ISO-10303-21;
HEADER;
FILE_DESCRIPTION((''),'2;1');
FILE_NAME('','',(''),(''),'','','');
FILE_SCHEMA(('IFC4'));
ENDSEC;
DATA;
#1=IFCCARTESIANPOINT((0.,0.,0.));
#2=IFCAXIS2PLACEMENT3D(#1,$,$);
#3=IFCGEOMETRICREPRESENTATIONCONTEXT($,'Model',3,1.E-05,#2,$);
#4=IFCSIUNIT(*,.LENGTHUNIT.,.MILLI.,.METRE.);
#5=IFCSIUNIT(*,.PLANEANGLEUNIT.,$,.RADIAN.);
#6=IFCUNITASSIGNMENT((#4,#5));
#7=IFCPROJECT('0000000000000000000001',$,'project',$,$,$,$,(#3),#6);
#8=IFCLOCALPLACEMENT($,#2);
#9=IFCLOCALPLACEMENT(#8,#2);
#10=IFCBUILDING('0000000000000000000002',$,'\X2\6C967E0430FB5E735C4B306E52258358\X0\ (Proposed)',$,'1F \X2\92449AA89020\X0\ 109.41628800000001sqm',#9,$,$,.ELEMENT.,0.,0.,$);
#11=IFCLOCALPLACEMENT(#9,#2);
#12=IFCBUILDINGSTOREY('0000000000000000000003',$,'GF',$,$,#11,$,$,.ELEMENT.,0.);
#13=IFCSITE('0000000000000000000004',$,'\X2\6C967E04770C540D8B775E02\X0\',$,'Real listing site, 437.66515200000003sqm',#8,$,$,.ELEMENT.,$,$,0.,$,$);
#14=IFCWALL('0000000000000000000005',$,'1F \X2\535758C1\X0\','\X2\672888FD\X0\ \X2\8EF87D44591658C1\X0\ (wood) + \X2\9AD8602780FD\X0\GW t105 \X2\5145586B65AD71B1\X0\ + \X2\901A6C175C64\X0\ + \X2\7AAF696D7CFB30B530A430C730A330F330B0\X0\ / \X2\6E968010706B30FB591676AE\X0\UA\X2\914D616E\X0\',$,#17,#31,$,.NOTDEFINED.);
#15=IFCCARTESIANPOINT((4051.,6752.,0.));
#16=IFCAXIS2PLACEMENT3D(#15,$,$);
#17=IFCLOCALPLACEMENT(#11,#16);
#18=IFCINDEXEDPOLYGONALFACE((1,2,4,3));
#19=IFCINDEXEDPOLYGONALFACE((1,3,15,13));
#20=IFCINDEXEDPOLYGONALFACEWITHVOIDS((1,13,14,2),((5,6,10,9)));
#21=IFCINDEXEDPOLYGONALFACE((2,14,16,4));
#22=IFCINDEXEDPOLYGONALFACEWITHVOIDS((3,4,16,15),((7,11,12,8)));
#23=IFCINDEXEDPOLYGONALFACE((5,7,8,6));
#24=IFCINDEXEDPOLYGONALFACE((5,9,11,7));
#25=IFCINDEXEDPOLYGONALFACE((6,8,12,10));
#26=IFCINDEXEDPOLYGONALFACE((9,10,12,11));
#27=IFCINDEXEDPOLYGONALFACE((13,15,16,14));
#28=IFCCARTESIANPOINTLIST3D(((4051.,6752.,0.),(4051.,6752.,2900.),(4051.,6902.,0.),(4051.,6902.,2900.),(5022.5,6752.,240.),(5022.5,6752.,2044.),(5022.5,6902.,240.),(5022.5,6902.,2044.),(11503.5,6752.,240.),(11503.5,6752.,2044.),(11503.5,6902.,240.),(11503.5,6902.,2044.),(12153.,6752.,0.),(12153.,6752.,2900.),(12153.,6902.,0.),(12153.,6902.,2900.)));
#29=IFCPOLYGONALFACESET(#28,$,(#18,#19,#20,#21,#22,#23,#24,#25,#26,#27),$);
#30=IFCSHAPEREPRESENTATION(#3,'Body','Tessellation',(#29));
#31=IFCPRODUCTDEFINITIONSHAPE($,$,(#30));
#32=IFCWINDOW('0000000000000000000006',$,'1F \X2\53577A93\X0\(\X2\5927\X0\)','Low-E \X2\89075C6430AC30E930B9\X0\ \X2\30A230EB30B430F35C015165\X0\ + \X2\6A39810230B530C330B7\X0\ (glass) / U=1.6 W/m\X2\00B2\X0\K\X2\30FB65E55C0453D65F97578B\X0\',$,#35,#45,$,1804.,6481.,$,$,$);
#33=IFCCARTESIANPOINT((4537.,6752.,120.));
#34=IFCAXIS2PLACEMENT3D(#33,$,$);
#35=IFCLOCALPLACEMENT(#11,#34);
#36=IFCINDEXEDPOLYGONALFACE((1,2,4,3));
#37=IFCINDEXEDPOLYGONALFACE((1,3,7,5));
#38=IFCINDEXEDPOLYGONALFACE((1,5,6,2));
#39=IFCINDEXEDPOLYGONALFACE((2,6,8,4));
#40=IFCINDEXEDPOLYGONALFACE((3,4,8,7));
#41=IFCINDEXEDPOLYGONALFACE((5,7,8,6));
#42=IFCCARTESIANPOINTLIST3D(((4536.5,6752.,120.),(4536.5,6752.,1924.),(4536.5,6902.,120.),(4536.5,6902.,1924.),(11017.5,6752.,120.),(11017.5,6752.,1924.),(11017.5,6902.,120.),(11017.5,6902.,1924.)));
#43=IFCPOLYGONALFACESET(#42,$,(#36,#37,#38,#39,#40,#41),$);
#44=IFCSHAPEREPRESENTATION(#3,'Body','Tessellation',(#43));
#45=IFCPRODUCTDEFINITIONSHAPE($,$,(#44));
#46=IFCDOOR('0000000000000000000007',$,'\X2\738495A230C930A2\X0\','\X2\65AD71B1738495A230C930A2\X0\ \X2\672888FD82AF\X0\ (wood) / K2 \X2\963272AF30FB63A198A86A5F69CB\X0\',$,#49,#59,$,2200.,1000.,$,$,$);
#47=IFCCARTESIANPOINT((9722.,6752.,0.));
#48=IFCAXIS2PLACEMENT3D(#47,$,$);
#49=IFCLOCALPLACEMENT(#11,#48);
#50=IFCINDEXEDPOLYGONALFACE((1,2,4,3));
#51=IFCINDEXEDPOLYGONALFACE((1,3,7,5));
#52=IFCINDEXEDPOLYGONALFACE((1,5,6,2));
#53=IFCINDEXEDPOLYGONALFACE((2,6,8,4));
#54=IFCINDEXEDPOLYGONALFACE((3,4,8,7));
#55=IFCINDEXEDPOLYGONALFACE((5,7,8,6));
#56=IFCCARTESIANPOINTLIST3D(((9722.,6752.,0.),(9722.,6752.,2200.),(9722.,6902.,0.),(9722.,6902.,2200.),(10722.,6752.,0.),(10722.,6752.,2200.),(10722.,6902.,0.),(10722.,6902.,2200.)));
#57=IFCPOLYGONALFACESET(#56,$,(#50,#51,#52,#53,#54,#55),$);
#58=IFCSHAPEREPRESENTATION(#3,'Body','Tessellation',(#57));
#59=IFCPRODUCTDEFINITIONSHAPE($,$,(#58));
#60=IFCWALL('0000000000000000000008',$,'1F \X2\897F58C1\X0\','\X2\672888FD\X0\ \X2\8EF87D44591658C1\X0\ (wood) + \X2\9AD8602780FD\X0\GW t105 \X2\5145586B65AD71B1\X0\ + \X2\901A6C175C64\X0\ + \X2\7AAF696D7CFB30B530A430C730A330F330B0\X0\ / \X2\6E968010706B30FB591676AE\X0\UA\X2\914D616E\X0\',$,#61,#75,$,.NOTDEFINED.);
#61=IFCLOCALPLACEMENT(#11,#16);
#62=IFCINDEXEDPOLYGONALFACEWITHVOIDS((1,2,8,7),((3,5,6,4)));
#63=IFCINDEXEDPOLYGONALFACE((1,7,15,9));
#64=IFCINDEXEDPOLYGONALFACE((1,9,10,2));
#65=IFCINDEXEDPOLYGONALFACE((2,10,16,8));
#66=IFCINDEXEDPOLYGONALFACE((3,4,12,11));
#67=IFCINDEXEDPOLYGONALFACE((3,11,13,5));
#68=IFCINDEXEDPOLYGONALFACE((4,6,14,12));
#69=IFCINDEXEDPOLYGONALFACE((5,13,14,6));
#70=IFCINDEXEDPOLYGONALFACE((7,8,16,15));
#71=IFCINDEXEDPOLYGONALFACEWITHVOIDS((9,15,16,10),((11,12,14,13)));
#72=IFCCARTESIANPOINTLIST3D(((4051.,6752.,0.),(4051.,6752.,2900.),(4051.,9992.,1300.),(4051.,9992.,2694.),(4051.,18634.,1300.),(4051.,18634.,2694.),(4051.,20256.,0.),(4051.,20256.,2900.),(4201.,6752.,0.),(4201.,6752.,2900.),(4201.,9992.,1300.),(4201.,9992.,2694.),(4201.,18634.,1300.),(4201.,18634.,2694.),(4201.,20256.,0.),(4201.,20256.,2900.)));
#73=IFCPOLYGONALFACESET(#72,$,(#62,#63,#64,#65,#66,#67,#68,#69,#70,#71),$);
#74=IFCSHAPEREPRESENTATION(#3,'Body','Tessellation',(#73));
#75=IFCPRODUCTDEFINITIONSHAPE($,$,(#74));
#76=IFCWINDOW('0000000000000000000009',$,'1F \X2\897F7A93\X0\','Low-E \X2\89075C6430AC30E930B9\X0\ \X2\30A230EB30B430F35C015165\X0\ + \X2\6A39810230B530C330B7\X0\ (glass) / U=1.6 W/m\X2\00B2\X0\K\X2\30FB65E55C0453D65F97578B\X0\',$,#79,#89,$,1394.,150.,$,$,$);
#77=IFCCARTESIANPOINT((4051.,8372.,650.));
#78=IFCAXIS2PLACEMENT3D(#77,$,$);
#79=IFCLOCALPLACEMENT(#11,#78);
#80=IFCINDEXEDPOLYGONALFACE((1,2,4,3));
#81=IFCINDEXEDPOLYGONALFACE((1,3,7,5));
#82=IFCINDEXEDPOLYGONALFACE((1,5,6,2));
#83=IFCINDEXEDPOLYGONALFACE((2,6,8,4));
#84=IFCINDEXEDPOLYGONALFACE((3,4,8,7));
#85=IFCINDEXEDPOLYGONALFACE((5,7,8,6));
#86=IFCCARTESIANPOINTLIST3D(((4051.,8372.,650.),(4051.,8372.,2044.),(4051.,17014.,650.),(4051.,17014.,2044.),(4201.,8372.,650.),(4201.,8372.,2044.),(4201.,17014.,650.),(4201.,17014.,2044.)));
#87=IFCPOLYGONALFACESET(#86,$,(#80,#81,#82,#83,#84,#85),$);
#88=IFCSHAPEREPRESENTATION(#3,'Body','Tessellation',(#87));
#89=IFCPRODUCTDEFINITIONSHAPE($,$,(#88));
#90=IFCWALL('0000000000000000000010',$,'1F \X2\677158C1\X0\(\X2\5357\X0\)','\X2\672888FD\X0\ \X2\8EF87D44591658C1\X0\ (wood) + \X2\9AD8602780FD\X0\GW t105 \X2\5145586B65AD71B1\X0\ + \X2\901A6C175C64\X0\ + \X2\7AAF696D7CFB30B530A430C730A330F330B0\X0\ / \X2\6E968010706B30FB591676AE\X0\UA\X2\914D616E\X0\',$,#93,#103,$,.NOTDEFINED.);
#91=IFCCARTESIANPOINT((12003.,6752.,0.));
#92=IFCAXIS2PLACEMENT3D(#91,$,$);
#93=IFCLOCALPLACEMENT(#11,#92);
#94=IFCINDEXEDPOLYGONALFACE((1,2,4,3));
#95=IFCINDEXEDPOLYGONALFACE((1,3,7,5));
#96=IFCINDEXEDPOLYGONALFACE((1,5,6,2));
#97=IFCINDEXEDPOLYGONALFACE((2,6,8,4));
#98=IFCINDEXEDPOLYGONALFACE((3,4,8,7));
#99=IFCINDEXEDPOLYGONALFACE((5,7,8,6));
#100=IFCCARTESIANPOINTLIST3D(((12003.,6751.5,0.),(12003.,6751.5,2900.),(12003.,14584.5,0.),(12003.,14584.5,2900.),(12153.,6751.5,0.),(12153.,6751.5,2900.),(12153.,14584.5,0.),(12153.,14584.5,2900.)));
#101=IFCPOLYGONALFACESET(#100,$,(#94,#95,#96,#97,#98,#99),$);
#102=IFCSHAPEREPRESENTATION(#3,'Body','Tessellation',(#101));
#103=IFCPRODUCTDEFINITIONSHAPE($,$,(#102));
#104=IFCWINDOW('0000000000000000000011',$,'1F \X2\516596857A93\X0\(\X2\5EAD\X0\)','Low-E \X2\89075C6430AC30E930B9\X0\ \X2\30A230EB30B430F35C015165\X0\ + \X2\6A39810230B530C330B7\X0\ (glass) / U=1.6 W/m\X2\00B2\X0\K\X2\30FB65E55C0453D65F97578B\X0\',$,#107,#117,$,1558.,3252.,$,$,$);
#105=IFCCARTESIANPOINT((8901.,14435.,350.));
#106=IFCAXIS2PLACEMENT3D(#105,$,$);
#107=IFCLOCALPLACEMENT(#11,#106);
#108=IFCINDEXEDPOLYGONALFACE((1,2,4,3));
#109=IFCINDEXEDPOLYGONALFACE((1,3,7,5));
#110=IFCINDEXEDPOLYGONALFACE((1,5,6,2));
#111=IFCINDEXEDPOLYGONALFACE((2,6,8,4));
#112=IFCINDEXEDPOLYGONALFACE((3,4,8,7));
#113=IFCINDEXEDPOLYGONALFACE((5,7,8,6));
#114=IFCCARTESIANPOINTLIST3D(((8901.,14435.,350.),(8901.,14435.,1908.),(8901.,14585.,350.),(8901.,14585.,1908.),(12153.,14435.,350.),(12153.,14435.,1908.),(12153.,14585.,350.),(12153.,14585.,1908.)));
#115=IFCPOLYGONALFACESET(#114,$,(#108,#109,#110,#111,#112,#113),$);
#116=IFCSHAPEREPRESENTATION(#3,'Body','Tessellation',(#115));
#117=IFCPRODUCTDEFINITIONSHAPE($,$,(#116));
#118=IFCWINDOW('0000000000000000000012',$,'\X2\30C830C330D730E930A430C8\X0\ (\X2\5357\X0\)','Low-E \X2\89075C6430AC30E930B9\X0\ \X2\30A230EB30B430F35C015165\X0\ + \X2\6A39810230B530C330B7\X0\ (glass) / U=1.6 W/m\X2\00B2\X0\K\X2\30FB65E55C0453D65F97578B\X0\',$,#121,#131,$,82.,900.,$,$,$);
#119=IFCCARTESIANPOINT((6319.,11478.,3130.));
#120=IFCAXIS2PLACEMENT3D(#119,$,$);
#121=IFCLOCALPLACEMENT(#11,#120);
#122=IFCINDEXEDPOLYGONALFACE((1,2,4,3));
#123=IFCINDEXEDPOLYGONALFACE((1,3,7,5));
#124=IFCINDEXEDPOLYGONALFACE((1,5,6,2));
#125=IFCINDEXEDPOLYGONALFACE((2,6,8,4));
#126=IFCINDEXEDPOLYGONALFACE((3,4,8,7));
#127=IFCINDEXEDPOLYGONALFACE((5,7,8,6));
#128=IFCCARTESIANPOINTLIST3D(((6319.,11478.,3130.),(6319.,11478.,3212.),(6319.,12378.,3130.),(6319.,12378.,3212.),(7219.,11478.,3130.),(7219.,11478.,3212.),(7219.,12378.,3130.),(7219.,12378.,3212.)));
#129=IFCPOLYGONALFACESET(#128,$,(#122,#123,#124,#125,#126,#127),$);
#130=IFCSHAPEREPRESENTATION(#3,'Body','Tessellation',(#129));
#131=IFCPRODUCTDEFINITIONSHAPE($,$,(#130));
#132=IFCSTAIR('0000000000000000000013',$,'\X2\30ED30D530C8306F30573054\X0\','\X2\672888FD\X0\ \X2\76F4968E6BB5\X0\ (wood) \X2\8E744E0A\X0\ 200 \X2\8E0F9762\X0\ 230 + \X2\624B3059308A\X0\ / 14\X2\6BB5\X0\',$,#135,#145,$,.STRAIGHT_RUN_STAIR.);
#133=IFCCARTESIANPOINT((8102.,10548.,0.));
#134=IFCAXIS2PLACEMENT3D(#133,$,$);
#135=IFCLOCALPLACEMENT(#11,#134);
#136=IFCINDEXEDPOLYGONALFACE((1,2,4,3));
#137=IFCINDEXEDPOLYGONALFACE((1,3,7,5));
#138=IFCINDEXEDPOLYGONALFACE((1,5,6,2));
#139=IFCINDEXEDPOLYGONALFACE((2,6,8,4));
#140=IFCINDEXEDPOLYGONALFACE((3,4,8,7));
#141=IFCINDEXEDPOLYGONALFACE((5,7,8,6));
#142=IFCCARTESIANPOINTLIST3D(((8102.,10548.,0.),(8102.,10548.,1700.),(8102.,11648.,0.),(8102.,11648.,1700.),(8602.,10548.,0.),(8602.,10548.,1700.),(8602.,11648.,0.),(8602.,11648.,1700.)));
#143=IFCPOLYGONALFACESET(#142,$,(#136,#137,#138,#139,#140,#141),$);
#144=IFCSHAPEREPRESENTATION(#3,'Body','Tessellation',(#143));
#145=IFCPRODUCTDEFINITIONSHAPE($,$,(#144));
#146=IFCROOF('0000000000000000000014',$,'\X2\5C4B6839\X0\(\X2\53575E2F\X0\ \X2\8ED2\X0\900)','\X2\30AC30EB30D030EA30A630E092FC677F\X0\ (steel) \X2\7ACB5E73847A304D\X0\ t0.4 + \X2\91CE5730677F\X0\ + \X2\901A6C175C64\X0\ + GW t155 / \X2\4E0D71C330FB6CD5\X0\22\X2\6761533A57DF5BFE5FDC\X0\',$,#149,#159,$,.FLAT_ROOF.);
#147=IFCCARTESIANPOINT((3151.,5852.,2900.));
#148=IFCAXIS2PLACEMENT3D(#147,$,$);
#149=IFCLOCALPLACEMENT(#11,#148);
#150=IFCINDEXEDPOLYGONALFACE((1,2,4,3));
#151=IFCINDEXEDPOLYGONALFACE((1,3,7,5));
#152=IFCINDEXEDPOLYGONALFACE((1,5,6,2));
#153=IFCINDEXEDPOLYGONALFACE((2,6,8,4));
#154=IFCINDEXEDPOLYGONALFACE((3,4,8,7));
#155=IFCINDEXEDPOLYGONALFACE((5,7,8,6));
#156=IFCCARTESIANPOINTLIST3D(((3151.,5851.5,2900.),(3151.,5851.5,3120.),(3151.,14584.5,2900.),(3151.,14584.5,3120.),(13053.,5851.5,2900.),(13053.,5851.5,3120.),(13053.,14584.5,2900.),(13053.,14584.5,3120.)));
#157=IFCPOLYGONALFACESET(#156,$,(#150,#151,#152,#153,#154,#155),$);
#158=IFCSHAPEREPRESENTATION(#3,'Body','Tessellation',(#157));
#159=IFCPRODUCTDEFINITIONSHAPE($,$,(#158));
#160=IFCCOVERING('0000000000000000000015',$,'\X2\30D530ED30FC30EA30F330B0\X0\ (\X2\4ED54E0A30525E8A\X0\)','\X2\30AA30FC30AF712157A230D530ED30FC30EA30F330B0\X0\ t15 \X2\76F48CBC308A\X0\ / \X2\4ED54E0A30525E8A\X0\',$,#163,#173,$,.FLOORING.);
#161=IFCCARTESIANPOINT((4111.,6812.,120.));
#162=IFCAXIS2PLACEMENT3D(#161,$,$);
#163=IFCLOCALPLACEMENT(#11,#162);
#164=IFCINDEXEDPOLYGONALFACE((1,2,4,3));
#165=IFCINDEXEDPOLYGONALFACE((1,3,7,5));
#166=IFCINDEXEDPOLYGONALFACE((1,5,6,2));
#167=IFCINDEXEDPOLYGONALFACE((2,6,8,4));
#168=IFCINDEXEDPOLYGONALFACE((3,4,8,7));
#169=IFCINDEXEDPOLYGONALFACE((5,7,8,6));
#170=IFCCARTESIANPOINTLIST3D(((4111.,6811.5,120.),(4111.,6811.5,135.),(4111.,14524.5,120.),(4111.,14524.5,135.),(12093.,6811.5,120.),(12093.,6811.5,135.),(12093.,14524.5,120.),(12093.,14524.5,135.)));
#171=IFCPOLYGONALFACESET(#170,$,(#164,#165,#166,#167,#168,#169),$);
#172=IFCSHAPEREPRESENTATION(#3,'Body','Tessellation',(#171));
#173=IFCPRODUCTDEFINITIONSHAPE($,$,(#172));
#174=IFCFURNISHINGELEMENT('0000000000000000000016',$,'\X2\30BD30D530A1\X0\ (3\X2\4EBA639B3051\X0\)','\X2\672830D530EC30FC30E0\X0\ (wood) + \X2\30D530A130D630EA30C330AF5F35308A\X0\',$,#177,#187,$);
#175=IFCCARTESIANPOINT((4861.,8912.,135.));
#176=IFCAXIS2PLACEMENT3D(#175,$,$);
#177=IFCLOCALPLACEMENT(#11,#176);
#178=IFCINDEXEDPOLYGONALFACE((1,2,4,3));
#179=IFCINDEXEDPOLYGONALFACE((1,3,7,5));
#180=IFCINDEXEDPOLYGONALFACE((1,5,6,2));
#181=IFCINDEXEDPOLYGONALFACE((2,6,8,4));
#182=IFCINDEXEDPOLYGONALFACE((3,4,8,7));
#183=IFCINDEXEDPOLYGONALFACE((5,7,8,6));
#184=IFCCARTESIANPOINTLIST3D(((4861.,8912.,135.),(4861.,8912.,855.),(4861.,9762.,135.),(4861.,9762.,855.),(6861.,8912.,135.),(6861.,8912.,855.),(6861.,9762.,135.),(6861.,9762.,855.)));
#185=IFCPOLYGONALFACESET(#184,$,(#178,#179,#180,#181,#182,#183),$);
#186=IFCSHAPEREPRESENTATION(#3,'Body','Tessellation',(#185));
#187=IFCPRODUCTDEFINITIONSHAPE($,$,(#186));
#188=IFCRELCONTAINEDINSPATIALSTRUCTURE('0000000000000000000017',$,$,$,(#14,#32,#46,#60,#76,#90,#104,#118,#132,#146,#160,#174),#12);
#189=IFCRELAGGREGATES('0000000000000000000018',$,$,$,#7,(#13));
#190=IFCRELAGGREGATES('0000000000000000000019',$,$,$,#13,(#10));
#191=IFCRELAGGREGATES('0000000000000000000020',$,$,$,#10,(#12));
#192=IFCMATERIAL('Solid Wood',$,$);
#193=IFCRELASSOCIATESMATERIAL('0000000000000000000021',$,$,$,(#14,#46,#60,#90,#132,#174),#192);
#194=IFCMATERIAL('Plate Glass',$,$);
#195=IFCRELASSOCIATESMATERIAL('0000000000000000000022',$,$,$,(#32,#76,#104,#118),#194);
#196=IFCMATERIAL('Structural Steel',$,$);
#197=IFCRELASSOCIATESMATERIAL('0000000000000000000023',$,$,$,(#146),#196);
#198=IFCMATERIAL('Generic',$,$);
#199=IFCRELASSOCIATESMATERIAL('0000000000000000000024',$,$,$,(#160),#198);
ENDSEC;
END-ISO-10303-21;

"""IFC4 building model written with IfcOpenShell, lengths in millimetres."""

from ifc_helpers import new_model, si_unit, frame, frame_2d, origin, place, context, project, spatial, rectangle, extrude, material, element, fill, save


model = new_model("IFC4")

# Units and contexts
model_context = context("Model", 3, precision=1e-05, world=origin())
ifc_project = project(units=[si_unit("LENGTHUNIT", "METRE", prefix="MILLI"), si_unit("PLANEANGLEUNIT", "RADIAN")], contexts=[model_context])

# Site, building, storey
site_placement = place(None, origin())
site = spatial("IfcSite", under=ifc_project, at=site_placement, Name="沖縄県名護市", ObjectType="Real listing site, 437.66515200000003sqm", CompositionType="ELEMENT", RefElevation=0.0)
building_placement = place(site_placement, origin())
building = spatial("IfcBuilding", under=site, at=building_placement, Name="沖縄・平屋の別荘 (Proposed)", ObjectType="1F 鉄骨造 109.41628800000001sqm", CompositionType="ELEMENT", ElevationOfRefHeight=0.0, ElevationOfTerrain=0.0)
storey_placement = place(building_placement, origin())
storey = spatial("IfcBuildingStorey", under=building, at=storey_placement, Name="GF", CompositionType="ELEMENT", Elevation=0.0)

# Shared definitions
ifc_material_1 = material(Name="Solid Wood")

# Wall, openings, window, door
wall_1_placement = place(storey_placement, frame((4051.0, 6752.0, 0.0)))
wall_1 = element("IfcWall", 1, at=wall_1_placement, inside=storey, material=ifc_material_1, Name="1F 南壁", Description="木製 軸組外壁 (wood) + 高性能GW t105 充填断熱 + 通気層 + 窯業系サイディング / 準耐火・外皮UA配慮", PredefinedType="NOTDEFINED", context=model_context, shape_type="SweptSolid", body=[
    extrude(rectangle(XDim=8102.0, YDim=150.0, at=frame_2d((4051.0, 75.0))), frame((4051.0, 6752.0, 0.0)), (0.0, 0.0, 1.0), 2900.0),
])
opening_1_placement = place(storey_placement, frame((4537.0, 6752.0, 120.0)))
opening_1 = element("IfcOpeningElement", 2, at=opening_1_placement, cuts=wall_1, PredefinedType="NOTDEFINED", context=model_context, shape_type="SweptSolid", body=[
    extrude(rectangle(XDim=6481.0, YDim=150.0, at=frame_2d((3240.0, 75.0))), frame((4537.0, 6752.0, 120.0)), (0.0, 0.0, 1.0), 1804.0),
])
opening_2_placement = place(storey_placement, frame((9722.0, 6752.0, 0.0)))
opening_2 = element("IfcOpeningElement", 3, at=opening_2_placement, cuts=wall_1, PredefinedType="NOTDEFINED", context=model_context, shape_type="SweptSolid", body=[
    extrude(rectangle(XDim=1000.0, YDim=150.0, at=frame_2d((500.0, 75.0))), frame((9722.0, 6752.0, 0.0)), (0.0, 0.0, 1.0), 2200.0),
])
ifc_material_2 = material(Name="Plate Glass")
window_1_placement = place(storey_placement, frame((4537.0, 6752.0, 120.0)))
window_1 = element("IfcWindow", 4, at=window_1_placement, inside=storey, material=ifc_material_2, Name="1F 南窓(大)", Description="Low-E 複層ガラス アルゴン封入 + 樹脂サッシ (glass) / U=1.6 W/m²K・日射取得型", OverallHeight=1804.0, OverallWidth=6481.0, context=model_context, shape_type="SweptSolid", body=[
    extrude(rectangle(XDim=6481.0, YDim=150.0, at=frame_2d((3240.0, 75.0))), frame((4537.0, 6752.0, 120.0)), (0.0, 0.0, 1.0), 1804.0),
])
fill(opening_1, window_1)
door_1_placement = place(storey_placement, frame((9722.0, 6752.0, 0.0)))
door_1 = element("IfcDoor", 5, at=door_1_placement, inside=storey, material=ifc_material_1, Name="玄関ドア", Description="断熱玄関ドア 木製芯 (wood) / K2 防犯・採風機構", OverallHeight=2200.0, OverallWidth=1000.0, context=model_context, shape_type="SweptSolid", body=[
    extrude(rectangle(XDim=1000.0, YDim=150.0, at=frame_2d((500.0, 75.0))), frame((9722.0, 6752.0, 0.0)), (0.0, 0.0, 1.0), 2200.0),
])
fill(opening_2, door_1)

# Walls, openings, windows
wall_2_placement = place(storey_placement, frame((4051.0, 6752.0, 0.0)))
wall_2 = element("IfcWall", 6, at=wall_2_placement, inside=storey, material=ifc_material_1, Name="1F 西壁", Description="木製 軸組外壁 (wood) + 高性能GW t105 充填断熱 + 通気層 + 窯業系サイディング / 準耐火・外皮UA配慮", PredefinedType="NOTDEFINED", context=model_context, shape_type="SweptSolid", body=[
    extrude(rectangle(XDim=150.0, YDim=13504.0, at=frame_2d((75.0, 6752.0))), frame((4051.0, 6752.0, 0.0)), (0.0, 0.0, 1.0), 2900.0),
])
opening_3_placement = place(storey_placement, frame((4051.0, 8372.0, 650.0)))
opening_3 = element("IfcOpeningElement", 7, at=opening_3_placement, cuts=wall_2, PredefinedType="NOTDEFINED", context=model_context, shape_type="SweptSolid", body=[
    extrude(rectangle(XDim=150.0, YDim=8642.0, at=frame_2d((75.0, 4321.0))), frame((4051.0, 8372.0, 650.0)), (0.0, 0.0, 1.0), 1394.0),
])
window_2_placement = place(storey_placement, frame((4051.0, 8372.0, 650.0)))
window_2 = element("IfcWindow", 8, at=window_2_placement, inside=storey, material=ifc_material_2, Name="1F 西窓", Description="Low-E 複層ガラス アルゴン封入 + 樹脂サッシ (glass) / U=1.6 W/m²K・日射取得型", OverallHeight=1394.0, OverallWidth=150.0, context=model_context, shape_type="SweptSolid", body=[
    extrude(rectangle(XDim=150.0, YDim=8642.0, at=frame_2d((75.0, 4321.0))), frame((4051.0, 8372.0, 650.0)), (0.0, 0.0, 1.0), 1394.0),
])
fill(opening_3, window_2)
wall_3_placement = place(storey_placement, frame((12003.0, 6752.0, 0.0)))
wall_3 = element("IfcWall", 9, at=wall_3_placement, inside=storey, material=ifc_material_1, Name="1F 東壁(南)", Description="木製 軸組外壁 (wood) + 高性能GW t105 充填断熱 + 通気層 + 窯業系サイディング / 準耐火・外皮UA配慮", PredefinedType="NOTDEFINED", context=model_context, shape_type="SweptSolid", body=[
    extrude(rectangle(XDim=150.0, YDim=7833.0, at=frame_2d((75.0, 3916.0))), frame((12003.0, 6752.0, 0.0)), (0.0, 0.0, 1.0), 2900.0),
])
opening_4_placement = place(storey_placement, frame((8901.0, 14435.0, 350.0)))
opening_4 = element("IfcOpeningElement", 10, at=opening_4_placement, cuts=wall_3, PredefinedType="NOTDEFINED", context=model_context, shape_type="SweptSolid", body=[
    extrude(rectangle(XDim=3252.0, YDim=150.0, at=frame_2d((1626.0, 75.0))), frame((8901.0, 14435.0, 350.0)), (0.0, 0.0, 1.0), 1558.0),
])
window_3_placement = place(storey_placement, frame((8901.0, 14435.0, 350.0)))
window_3 = element("IfcWindow", 11, at=window_3_placement, inside=storey, material=ifc_material_2, Name="1F 入隅窓(庭)", Description="Low-E 複層ガラス アルゴン封入 + 樹脂サッシ (glass) / U=1.6 W/m²K・日射取得型", OverallHeight=1558.0, OverallWidth=3252.0, context=model_context, shape_type="SweptSolid", body=[
    extrude(rectangle(XDim=3252.0, YDim=150.0, at=frame_2d((1626.0, 75.0))), frame((8901.0, 14435.0, 350.0)), (0.0, 0.0, 1.0), 1558.0),
])
fill(opening_4, window_3)

# Window
window_4_placement = place(storey_placement, frame((6319.0, 11478.0, 3130.0)))
element("IfcWindow", 12, at=window_4_placement, inside=storey, material=ifc_material_2, Name="トップライト (南)", Description="Low-E 複層ガラス アルゴン封入 + 樹脂サッシ (glass) / U=1.6 W/m²K・日射取得型", OverallHeight=82.0, OverallWidth=900.0, context=model_context, shape_type="SweptSolid", body=[
    extrude(rectangle(XDim=900.0, YDim=900.0, at=frame_2d((450.0, 450.0))), frame((6319.0, 11478.0, 3130.0)), (0.0, 0.0, 1.0), 82.0),
])

# Stair
stair_placement = place(storey_placement, frame((8102.0, 10548.0, 0.0)))
element("IfcStair", 13, at=stair_placement, inside=storey, material=ifc_material_1, Name="ロフトはしご", Description="木製 直階段 (wood) 蹴上 200 踏面 230 + 手すり / 14段", PredefinedType="STRAIGHT_RUN_STAIR", context=model_context, shape_type="SweptSolid", body=[
    extrude(rectangle(XDim=500.0, YDim=1100.0, at=frame_2d((250.0, 550.0))), frame((8102.0, 10548.0, 0.0)), (0.0, 0.0, 1.0), 1700.0),
])

# Roof
ifc_material_3 = material(Name="Structural Steel")
roof_placement = place(storey_placement, frame((3151.0, 5852.0, 2900.0)))
element("IfcRoof", 14, at=roof_placement, inside=storey, material=ifc_material_3, Name="屋根(南帯 軒900)", Description="ガルバリウム鋼板 (steel) 立平葺き t0.4 + 野地板 + 通気層 + GW t155 / 不燃・法22条区域対応", PredefinedType="FLAT_ROOF", context=model_context, shape_type="SweptSolid", body=[
    extrude(rectangle(XDim=9902.0, YDim=8733.0, at=frame_2d((4951.0, 4366.0))), frame((3151.0, 5852.0, 2900.0)), (0.0, 0.0, 1.0), 220.0),
])

# Covering
ifc_material_4 = material(Name="Generic")
covering_placement = place(storey_placement, frame((4111.0, 6812.0, 120.0)))
element("IfcCovering", 15, at=covering_placement, inside=storey, material=ifc_material_4, Name="フローリング (仕上げ床)", Description="オーク無垢フローリング t15 直貼り / 仕上げ床", PredefinedType="FLOORING", context=model_context, shape_type="SweptSolid", body=[
    extrude(rectangle(XDim=7982.0, YDim=7713.0, at=frame_2d((3991.0, 3856.0))), frame((4111.0, 6812.0, 120.0)), (0.0, 0.0, 1.0), 15.0),
])

# Furnishing element
furnishing_1_placement = place(storey_placement, frame((4861.0, 8912.0, 135.0)))
element("IfcFurnishingElement", 16, at=furnishing_1_placement, inside=storey, material=ifc_material_1, Name="ソファ (3人掛け)", Description="木フレーム (wood) + ファブリック張り", context=model_context, shape_type="SweptSolid", body=[
    extrude(rectangle(XDim=2000.0, YDim=850.0, at=frame_2d((1000.0, 425.0))), frame((4861.0, 8912.0, 135.0)), (0.0, 0.0, 1.0), 720.0),
])

save(model, "model.ifc")
